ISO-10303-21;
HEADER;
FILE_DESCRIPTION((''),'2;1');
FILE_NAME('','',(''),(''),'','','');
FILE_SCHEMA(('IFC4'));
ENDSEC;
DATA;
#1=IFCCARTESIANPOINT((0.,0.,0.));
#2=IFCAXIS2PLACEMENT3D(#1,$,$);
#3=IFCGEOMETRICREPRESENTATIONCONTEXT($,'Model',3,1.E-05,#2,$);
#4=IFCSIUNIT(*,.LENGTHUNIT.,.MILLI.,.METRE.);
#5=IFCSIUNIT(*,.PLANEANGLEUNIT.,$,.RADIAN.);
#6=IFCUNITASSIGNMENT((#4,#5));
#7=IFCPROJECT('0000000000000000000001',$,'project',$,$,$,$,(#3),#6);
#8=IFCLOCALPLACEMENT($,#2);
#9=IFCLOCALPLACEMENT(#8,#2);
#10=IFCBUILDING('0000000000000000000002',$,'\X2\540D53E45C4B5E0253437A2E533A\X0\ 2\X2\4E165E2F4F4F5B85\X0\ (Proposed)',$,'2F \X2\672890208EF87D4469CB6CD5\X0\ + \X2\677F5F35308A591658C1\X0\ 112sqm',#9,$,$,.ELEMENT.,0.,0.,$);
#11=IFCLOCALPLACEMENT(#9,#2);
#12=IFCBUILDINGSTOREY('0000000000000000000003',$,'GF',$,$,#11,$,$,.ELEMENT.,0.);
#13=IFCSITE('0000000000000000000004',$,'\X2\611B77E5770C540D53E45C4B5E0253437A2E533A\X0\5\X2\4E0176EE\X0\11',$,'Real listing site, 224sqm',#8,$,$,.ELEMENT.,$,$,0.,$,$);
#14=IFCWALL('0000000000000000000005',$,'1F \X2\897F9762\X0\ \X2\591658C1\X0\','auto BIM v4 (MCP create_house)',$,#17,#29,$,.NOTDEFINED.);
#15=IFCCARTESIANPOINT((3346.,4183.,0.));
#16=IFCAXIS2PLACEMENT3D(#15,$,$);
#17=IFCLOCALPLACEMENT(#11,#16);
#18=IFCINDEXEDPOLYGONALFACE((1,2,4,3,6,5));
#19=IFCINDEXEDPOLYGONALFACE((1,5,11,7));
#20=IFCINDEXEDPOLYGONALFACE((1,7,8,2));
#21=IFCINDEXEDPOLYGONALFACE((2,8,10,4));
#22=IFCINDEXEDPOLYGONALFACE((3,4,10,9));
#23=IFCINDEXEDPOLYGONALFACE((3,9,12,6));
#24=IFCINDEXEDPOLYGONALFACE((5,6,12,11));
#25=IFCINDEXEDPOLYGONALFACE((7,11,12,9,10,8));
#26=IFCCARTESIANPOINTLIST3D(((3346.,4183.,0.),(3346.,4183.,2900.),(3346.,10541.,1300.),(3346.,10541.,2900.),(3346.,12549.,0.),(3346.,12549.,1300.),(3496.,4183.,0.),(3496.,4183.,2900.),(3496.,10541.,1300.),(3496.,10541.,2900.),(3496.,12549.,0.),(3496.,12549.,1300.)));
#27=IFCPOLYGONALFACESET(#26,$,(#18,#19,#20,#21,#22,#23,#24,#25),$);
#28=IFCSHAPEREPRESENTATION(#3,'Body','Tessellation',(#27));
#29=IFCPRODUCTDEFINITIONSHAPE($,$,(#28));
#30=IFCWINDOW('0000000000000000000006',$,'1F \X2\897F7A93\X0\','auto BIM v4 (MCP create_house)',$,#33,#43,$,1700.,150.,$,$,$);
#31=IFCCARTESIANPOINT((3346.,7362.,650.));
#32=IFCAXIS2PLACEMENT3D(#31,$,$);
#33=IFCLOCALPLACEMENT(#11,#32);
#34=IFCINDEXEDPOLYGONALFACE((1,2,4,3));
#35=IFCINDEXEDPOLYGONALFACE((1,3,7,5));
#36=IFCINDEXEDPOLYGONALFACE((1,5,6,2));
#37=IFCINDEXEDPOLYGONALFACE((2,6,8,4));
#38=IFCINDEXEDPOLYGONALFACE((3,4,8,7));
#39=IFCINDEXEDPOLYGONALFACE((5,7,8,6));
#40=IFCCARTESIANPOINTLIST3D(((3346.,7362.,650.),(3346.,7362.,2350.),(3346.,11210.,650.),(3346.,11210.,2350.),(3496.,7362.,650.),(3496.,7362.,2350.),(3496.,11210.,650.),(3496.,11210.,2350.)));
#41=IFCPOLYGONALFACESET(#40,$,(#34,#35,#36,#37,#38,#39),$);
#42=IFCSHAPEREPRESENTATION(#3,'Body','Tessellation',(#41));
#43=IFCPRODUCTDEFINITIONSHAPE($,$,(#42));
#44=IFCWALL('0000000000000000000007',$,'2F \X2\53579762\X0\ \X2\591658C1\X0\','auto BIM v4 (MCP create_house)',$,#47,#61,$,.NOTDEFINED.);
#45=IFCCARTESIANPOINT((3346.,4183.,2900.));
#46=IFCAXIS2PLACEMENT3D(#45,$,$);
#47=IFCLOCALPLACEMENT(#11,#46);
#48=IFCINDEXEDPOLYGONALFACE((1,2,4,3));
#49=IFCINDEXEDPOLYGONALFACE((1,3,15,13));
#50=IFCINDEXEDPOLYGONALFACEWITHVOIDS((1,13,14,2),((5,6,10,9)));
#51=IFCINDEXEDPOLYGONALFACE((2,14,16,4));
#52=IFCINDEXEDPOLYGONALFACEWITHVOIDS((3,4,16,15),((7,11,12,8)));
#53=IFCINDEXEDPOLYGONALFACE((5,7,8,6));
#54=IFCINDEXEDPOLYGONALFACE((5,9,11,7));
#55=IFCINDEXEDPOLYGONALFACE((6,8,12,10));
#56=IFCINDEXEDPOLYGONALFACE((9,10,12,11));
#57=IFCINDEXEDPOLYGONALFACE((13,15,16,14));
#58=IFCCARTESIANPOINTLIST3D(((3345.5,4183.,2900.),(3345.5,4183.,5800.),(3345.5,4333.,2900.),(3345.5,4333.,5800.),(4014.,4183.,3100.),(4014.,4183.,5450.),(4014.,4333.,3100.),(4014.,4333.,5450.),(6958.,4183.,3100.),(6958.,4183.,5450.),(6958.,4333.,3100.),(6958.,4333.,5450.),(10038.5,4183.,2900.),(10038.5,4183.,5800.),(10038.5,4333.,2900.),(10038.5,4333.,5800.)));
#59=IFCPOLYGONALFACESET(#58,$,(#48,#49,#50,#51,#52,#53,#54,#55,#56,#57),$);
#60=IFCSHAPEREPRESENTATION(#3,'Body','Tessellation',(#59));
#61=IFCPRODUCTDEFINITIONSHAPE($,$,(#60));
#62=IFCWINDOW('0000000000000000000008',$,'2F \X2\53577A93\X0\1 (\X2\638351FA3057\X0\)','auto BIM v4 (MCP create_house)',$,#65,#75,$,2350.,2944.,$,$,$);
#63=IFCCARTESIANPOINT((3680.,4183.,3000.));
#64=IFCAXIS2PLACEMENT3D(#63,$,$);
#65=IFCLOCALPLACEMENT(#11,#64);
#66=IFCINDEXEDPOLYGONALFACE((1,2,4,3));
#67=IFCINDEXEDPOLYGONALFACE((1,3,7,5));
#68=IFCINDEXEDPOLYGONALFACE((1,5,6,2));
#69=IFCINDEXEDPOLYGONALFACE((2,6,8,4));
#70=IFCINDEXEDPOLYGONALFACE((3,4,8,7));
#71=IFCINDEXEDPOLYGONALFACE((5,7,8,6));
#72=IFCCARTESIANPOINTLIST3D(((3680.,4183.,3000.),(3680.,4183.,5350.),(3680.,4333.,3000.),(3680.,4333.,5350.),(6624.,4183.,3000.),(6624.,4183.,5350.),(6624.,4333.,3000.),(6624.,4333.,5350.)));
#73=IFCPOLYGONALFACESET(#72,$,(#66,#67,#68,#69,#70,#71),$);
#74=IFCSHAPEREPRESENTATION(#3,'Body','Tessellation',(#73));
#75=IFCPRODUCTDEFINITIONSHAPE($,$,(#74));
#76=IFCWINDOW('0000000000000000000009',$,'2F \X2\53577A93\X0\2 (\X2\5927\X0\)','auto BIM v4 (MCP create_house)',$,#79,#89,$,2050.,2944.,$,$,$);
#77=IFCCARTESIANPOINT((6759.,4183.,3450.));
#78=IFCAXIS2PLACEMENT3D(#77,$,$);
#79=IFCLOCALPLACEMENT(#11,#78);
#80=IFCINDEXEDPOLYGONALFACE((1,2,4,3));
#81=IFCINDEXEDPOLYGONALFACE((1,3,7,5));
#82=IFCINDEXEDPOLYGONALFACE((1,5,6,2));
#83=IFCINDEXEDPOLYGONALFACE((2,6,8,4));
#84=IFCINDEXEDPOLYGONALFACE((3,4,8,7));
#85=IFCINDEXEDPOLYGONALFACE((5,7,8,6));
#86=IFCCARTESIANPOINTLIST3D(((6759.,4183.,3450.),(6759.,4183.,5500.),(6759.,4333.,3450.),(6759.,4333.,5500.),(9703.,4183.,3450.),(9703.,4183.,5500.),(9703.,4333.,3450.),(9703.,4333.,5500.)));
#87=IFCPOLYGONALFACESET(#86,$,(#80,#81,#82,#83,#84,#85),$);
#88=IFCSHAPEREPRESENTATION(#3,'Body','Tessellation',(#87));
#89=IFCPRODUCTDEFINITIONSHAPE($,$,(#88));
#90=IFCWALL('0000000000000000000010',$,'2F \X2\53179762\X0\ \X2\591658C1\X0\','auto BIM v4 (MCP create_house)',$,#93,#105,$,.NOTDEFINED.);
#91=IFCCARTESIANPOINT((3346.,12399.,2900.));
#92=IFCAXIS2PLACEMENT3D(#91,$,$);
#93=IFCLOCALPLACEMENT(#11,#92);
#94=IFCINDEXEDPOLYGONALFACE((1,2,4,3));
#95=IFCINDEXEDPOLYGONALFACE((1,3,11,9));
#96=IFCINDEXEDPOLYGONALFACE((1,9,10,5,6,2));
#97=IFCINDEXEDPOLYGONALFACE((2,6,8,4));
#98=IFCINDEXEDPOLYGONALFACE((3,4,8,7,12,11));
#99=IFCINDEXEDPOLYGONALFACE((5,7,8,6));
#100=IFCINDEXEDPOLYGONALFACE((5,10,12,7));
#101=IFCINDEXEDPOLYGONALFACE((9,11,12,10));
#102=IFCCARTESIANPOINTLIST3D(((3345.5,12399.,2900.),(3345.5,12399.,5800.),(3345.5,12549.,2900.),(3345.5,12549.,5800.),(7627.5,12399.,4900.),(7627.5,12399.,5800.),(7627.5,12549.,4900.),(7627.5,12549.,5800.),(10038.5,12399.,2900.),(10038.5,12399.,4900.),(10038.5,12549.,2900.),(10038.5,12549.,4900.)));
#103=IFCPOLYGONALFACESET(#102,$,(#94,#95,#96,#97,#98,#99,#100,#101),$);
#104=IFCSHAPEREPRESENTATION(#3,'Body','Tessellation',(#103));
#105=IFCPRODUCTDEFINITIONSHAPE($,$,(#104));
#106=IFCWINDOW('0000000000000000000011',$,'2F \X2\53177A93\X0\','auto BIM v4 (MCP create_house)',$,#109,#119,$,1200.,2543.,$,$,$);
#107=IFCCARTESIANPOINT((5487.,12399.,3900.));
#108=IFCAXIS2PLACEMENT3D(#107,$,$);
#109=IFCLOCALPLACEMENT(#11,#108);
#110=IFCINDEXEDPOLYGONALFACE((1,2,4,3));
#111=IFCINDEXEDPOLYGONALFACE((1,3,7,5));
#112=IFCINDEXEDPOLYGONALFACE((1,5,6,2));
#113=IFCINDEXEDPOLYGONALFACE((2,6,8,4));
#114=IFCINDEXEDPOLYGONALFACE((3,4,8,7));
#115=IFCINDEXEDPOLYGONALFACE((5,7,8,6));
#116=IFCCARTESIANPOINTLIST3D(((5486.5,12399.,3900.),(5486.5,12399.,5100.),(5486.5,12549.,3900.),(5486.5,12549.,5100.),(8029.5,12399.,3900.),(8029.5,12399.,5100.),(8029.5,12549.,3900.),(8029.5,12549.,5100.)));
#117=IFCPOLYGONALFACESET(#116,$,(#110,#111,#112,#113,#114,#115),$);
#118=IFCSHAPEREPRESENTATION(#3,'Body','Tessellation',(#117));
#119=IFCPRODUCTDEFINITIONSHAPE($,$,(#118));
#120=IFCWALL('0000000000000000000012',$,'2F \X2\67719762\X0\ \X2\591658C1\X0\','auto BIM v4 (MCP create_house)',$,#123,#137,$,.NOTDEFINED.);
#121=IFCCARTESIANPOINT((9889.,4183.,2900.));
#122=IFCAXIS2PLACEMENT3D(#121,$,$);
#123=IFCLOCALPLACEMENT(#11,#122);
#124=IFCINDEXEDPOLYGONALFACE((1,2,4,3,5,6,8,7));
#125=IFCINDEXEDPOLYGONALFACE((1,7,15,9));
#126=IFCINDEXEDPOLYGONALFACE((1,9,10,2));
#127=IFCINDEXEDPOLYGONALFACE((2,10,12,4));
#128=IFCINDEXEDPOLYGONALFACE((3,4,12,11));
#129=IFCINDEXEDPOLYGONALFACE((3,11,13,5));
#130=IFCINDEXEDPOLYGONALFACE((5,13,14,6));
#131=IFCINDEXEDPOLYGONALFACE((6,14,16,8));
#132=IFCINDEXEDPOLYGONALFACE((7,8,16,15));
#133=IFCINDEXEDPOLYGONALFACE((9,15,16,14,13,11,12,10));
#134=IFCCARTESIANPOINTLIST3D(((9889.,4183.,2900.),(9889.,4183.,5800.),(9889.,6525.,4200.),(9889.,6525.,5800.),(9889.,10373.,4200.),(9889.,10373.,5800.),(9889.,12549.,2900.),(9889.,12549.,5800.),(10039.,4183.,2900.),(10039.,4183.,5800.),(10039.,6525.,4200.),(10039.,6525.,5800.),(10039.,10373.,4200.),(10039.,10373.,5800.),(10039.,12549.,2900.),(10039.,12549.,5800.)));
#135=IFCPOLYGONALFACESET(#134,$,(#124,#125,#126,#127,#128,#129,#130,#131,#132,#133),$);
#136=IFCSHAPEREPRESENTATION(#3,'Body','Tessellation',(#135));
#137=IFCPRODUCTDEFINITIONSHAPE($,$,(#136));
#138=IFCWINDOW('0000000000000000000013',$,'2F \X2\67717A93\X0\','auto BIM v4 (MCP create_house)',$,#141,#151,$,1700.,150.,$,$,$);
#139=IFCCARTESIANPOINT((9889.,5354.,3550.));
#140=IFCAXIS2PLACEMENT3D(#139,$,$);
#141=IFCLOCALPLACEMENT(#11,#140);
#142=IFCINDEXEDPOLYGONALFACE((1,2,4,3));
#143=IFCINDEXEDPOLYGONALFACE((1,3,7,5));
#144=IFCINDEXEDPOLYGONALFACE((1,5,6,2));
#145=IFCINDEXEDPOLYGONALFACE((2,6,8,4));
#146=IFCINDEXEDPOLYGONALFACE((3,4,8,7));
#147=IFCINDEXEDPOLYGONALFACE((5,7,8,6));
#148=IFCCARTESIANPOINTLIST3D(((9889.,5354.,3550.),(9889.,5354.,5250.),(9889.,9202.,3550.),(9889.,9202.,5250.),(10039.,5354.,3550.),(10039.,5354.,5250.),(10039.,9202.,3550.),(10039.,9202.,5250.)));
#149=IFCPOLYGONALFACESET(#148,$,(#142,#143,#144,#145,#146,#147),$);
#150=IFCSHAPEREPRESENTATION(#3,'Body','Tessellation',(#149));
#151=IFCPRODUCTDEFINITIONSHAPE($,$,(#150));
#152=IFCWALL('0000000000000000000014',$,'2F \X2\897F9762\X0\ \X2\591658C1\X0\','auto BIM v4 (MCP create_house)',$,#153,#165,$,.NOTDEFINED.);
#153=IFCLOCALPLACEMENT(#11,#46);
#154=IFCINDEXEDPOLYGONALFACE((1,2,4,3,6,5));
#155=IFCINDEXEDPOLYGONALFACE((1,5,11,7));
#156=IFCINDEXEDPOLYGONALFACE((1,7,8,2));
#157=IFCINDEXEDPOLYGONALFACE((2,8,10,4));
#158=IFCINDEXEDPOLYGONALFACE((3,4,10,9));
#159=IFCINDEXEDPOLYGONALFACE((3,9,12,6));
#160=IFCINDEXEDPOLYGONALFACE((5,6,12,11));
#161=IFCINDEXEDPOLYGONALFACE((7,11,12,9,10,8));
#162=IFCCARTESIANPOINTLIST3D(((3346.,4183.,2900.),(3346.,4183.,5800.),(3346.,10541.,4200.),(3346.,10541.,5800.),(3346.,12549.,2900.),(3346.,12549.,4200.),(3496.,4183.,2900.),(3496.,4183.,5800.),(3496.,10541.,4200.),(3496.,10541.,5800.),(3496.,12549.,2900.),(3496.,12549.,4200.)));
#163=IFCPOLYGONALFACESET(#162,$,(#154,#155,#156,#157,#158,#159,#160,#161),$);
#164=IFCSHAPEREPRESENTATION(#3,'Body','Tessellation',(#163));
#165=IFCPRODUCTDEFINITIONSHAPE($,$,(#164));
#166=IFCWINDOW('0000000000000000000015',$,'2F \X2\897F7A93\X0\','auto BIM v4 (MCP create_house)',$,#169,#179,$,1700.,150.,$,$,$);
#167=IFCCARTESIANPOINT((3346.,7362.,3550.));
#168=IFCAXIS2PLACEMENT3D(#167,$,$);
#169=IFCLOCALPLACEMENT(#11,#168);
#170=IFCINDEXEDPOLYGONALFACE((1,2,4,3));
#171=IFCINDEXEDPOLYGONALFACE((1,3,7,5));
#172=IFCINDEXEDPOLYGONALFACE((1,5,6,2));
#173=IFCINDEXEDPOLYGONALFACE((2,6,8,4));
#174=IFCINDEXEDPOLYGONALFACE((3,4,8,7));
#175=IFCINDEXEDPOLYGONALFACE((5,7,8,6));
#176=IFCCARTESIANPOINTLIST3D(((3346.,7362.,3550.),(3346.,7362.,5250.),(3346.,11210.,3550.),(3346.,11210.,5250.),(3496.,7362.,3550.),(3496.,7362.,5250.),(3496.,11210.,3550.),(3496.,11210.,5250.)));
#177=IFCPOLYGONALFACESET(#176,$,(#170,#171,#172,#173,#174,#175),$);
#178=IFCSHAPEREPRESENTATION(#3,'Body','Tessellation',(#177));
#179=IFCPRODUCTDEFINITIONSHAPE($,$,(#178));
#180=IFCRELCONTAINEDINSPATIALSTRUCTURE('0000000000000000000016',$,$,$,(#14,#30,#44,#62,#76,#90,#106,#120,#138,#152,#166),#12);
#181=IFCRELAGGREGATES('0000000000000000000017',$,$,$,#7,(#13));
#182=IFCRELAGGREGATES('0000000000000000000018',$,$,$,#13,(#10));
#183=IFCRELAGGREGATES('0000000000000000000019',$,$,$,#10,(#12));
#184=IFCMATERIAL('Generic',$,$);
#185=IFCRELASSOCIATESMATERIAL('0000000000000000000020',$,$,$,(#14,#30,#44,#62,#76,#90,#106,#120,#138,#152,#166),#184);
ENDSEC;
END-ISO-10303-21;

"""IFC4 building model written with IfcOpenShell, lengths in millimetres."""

from ifc_helpers import new_model, si_unit, frame, frame_2d, origin, place, context, project, spatial, rectangle, extrude, material, element, fill, save


model = new_model("IFC4")

# Units and contexts
model_context = context("Model", 3, precision=1e-05, world=origin())
ifc_project = project(units=[si_unit("LENGTHUNIT", "METRE", prefix="MILLI"), si_unit("PLANEANGLEUNIT", "RADIAN")], contexts=[model_context])

# Site, building, storey
site_placement = place(None, origin())
site = spatial("IfcSite", under=ifc_project, at=site_placement, Name="愛知県名古屋市千種区5丁目11", ObjectType="Real listing site, 224sqm", CompositionType="ELEMENT", RefElevation=0.0)
building_placement = place(site_placement, origin())
building = spatial("IfcBuilding", under=site, at=building_placement, Name="名古屋市千種区 2世帯住宅 (Proposed)", ObjectType="2F 木造軸組構法 + 板張り外壁 112sqm", CompositionType="ELEMENT", ElevationOfRefHeight=0.0, ElevationOfTerrain=0.0)
storey_placement = place(building_placement, origin())
storey = spatial("IfcBuildingStorey", under=building, at=storey_placement, Name="GF", CompositionType="ELEMENT", Elevation=0.0)

# Shared definitions
ifc_material = material(Name="Generic")

# Wall, opening, window
wall_1_placement = place(storey_placement, frame((3346.0, 4183.0, 0.0)))
wall_1 = element("IfcWall", 1, at=wall_1_placement, inside=storey, material=ifc_material, Name="1F 西面 外壁", Description="auto BIM v4 (MCP create_house)", PredefinedType="NOTDEFINED", context=model_context, shape_type="SweptSolid", body=[
    extrude(rectangle(XDim=150.0, YDim=8366.0, at=frame_2d((75.0, 4183.0))), frame((3346.0, 4183.0, 0.0)), (0.0, 0.0, 1.0), 2900.0),
])
opening_1_placement = place(storey_placement, frame((3346.0, 7362.0, 650.0)))
opening_1 = element("IfcOpeningElement", 2, at=opening_1_placement, cuts=wall_1, PredefinedType="NOTDEFINED", context=model_context, shape_type="SweptSolid", body=[
    extrude(rectangle(XDim=150.0, YDim=3848.0, at=frame_2d((75.0, 1924.0))), frame((3346.0, 7362.0, 650.0)), (0.0, 0.0, 1.0), 1700.0),
])
window_1_placement = place(storey_placement, frame((3346.0, 7362.0, 650.0)))
window_1 = element("IfcWindow", 3, at=window_1_placement, inside=storey, material=ifc_material, Name="1F 西窓", Description="auto BIM v4 (MCP create_house)", OverallHeight=1700.0, OverallWidth=150.0, context=model_context, shape_type="SweptSolid", body=[
    extrude(rectangle(XDim=150.0, YDim=3848.0, at=frame_2d((75.0, 1924.0))), frame((3346.0, 7362.0, 650.0)), (0.0, 0.0, 1.0), 1700.0),
])
fill(opening_1, window_1)

# Wall, openings, windows
wall_2_placement = place(storey_placement, frame((3346.0, 4183.0, 2900.0)))
wall_2 = element("IfcWall", 4, at=wall_2_placement, inside=storey, material=ifc_material, Name="2F 南面 外壁", Description="auto BIM v4 (MCP create_house)", PredefinedType="NOTDEFINED", context=model_context, shape_type="SweptSolid", body=[
    extrude(rectangle(XDim=6693.0, YDim=150.0, at=frame_2d((3346.0, 75.0))), frame((3346.0, 4183.0, 2900.0)), (0.0, 0.0, 1.0), 2900.0),
])
opening_2_placement = place(storey_placement, frame((3680.0, 4183.0, 3000.0)))
opening_2 = element("IfcOpeningElement", 5, at=opening_2_placement, cuts=wall_2, PredefinedType="NOTDEFINED", context=model_context, shape_type="SweptSolid", body=[
    extrude(rectangle(XDim=2944.0, YDim=150.0, at=frame_2d((1472.0, 75.0))), frame((3680.0, 4183.0, 3000.0)), (0.0, 0.0, 1.0), 2350.0),
])
opening_3_placement = place(storey_placement, frame((6759.0, 4183.0, 3450.0)))
opening_3 = element("IfcOpeningElement", 6, at=opening_3_placement, cuts=wall_2, PredefinedType="NOTDEFINED", context=model_context, shape_type="SweptSolid", body=[
    extrude(rectangle(XDim=2944.0, YDim=150.0, at=frame_2d((1472.0, 75.0))), frame((6759.0, 4183.0, 3450.0)), (0.0, 0.0, 1.0), 2050.0),
])
window_2_placement = place(storey_placement, frame((3680.0, 4183.0, 3000.0)))
window_2 = element("IfcWindow", 7, at=window_2_placement, inside=storey, material=ifc_material, Name="2F 南窓1 (掃出し)", Description="auto BIM v4 (MCP create_house)", OverallHeight=2350.0, OverallWidth=2944.0, context=model_context, shape_type="SweptSolid", body=[
    extrude(rectangle(XDim=2944.0, YDim=150.0, at=frame_2d((1472.0, 75.0))), frame((3680.0, 4183.0, 3000.0)), (0.0, 0.0, 1.0), 2350.0),
])
fill(opening_2, window_2)
window_3_placement = place(storey_placement, frame((6759.0, 4183.0, 3450.0)))
window_3 = element("IfcWindow", 8, at=window_3_placement, inside=storey, material=ifc_material, Name="2F 南窓2 (大)", Description="auto BIM v4 (MCP create_house)", OverallHeight=2050.0, OverallWidth=2944.0, context=model_context, shape_type="SweptSolid", body=[
    extrude(rectangle(XDim=2944.0, YDim=150.0, at=frame_2d((1472.0, 75.0))), frame((6759.0, 4183.0, 3450.0)), (0.0, 0.0, 1.0), 2050.0),
])
fill(opening_3, window_3)

# Walls, openings, windows
wall_3_placement = place(storey_placement, frame((3346.0, 12399.0, 2900.0)))
wall_3 = element("IfcWall", 9, at=wall_3_placement, inside=storey, material=ifc_material, Name="2F 北面 外壁", Description="auto BIM v4 (MCP create_house)", PredefinedType="NOTDEFINED", context=model_context, shape_type="SweptSolid", body=[
    extrude(rectangle(XDim=6693.0, YDim=150.0, at=frame_2d((3346.0, 75.0))), frame((3346.0, 12399.0, 2900.0)), (0.0, 0.0, 1.0), 2900.0),
])
opening_4_placement = place(storey_placement, frame((5487.0, 12399.0, 3900.0)))
opening_4 = element("IfcOpeningElement", 10, at=opening_4_placement, cuts=wall_3, PredefinedType="NOTDEFINED", context=model_context, shape_type="SweptSolid", body=[
    extrude(rectangle(XDim=2543.0, YDim=150.0, at=frame_2d((1271.0, 75.0))), frame((5487.0, 12399.0, 3900.0)), (0.0, 0.0, 1.0), 1200.0),
])
window_4_placement = place(storey_placement, frame((5487.0, 12399.0, 3900.0)))
window_4 = element("IfcWindow", 11, at=window_4_placement, inside=storey, material=ifc_material, Name="2F 北窓", Description="auto BIM v4 (MCP create_house)", OverallHeight=1200.0, OverallWidth=2543.0, context=model_context, shape_type="SweptSolid", body=[
    extrude(rectangle(XDim=2543.0, YDim=150.0, at=frame_2d((1271.0, 75.0))), frame((5487.0, 12399.0, 3900.0)), (0.0, 0.0, 1.0), 1200.0),
])
fill(opening_4, window_4)
wall_4_placement = place(storey_placement, frame((9889.0, 4183.0, 2900.0)))
wall_4 = element("IfcWall", 12, at=wall_4_placement, inside=storey, material=ifc_material, Name="2F 東面 外壁", Description="auto BIM v4 (MCP create_house)", PredefinedType="NOTDEFINED", context=model_context, shape_type="SweptSolid", body=[
    extrude(rectangle(XDim=150.0, YDim=8366.0, at=frame_2d((75.0, 4183.0))), frame((9889.0, 4183.0, 2900.0)), (0.0, 0.0, 1.0), 2900.0),
])
opening_5_placement = place(storey_placement, frame((9889.0, 5354.0, 3550.0)))
opening_5 = element("IfcOpeningElement", 13, at=opening_5_placement, cuts=wall_4, PredefinedType="NOTDEFINED", context=model_context, shape_type="SweptSolid", body=[
    extrude(rectangle(XDim=150.0, YDim=3848.0, at=frame_2d((75.0, 1924.0))), frame((9889.0, 5354.0, 3550.0)), (0.0, 0.0, 1.0), 1700.0),
])
window_5_placement = place(storey_placement, frame((9889.0, 5354.0, 3550.0)))
window_5 = element("IfcWindow", 14, at=window_5_placement, inside=storey, material=ifc_material, Name="2F 東窓", Description="auto BIM v4 (MCP create_house)", OverallHeight=1700.0, OverallWidth=150.0, context=model_context, shape_type="SweptSolid", body=[
    extrude(rectangle(XDim=150.0, YDim=3848.0, at=frame_2d((75.0, 1924.0))), frame((9889.0, 5354.0, 3550.0)), (0.0, 0.0, 1.0), 1700.0),
])
fill(opening_5, window_5)
wall_5_placement = place(storey_placement, frame((3346.0, 4183.0, 2900.0)))
wall_5 = element("IfcWall", 15, at=wall_5_placement, inside=storey, material=ifc_material, Name="2F 西面 外壁", Description="auto BIM v4 (MCP create_house)", PredefinedType="NOTDEFINED", context=model_context, shape_type="SweptSolid", body=[
    extrude(rectangle(XDim=150.0, YDim=8366.0, at=frame_2d((75.0, 4183.0))), frame((3346.0, 4183.0, 2900.0)), (0.0, 0.0, 1.0), 2900.0),
])
opening_6_placement = place(storey_placement, frame((3346.0, 7362.0, 3550.0)))
opening_6 = element("IfcOpeningElement", 16, at=opening_6_placement, cuts=wall_5, PredefinedType="NOTDEFINED", context=model_context, shape_type="SweptSolid", body=[
    extrude(rectangle(XDim=150.0, YDim=3848.0, at=frame_2d((75.0, 1924.0))), frame((3346.0, 7362.0, 3550.0)), (0.0, 0.0, 1.0), 1700.0),
])
window_6_placement = place(storey_placement, frame((3346.0, 7362.0, 3550.0)))
window_6 = element("IfcWindow", 17, at=window_6_placement, inside=storey, material=ifc_material, Name="2F 西窓", Description="auto BIM v4 (MCP create_house)", OverallHeight=1700.0, OverallWidth=150.0, context=model_context, shape_type="SweptSolid", body=[
    extrude(rectangle(XDim=150.0, YDim=3848.0, at=frame_2d((75.0, 1924.0))), frame((3346.0, 7362.0, 3550.0)), (0.0, 0.0, 1.0), 1700.0),
])
fill(opening_6, window_6)

save(model, "model.ifc")
